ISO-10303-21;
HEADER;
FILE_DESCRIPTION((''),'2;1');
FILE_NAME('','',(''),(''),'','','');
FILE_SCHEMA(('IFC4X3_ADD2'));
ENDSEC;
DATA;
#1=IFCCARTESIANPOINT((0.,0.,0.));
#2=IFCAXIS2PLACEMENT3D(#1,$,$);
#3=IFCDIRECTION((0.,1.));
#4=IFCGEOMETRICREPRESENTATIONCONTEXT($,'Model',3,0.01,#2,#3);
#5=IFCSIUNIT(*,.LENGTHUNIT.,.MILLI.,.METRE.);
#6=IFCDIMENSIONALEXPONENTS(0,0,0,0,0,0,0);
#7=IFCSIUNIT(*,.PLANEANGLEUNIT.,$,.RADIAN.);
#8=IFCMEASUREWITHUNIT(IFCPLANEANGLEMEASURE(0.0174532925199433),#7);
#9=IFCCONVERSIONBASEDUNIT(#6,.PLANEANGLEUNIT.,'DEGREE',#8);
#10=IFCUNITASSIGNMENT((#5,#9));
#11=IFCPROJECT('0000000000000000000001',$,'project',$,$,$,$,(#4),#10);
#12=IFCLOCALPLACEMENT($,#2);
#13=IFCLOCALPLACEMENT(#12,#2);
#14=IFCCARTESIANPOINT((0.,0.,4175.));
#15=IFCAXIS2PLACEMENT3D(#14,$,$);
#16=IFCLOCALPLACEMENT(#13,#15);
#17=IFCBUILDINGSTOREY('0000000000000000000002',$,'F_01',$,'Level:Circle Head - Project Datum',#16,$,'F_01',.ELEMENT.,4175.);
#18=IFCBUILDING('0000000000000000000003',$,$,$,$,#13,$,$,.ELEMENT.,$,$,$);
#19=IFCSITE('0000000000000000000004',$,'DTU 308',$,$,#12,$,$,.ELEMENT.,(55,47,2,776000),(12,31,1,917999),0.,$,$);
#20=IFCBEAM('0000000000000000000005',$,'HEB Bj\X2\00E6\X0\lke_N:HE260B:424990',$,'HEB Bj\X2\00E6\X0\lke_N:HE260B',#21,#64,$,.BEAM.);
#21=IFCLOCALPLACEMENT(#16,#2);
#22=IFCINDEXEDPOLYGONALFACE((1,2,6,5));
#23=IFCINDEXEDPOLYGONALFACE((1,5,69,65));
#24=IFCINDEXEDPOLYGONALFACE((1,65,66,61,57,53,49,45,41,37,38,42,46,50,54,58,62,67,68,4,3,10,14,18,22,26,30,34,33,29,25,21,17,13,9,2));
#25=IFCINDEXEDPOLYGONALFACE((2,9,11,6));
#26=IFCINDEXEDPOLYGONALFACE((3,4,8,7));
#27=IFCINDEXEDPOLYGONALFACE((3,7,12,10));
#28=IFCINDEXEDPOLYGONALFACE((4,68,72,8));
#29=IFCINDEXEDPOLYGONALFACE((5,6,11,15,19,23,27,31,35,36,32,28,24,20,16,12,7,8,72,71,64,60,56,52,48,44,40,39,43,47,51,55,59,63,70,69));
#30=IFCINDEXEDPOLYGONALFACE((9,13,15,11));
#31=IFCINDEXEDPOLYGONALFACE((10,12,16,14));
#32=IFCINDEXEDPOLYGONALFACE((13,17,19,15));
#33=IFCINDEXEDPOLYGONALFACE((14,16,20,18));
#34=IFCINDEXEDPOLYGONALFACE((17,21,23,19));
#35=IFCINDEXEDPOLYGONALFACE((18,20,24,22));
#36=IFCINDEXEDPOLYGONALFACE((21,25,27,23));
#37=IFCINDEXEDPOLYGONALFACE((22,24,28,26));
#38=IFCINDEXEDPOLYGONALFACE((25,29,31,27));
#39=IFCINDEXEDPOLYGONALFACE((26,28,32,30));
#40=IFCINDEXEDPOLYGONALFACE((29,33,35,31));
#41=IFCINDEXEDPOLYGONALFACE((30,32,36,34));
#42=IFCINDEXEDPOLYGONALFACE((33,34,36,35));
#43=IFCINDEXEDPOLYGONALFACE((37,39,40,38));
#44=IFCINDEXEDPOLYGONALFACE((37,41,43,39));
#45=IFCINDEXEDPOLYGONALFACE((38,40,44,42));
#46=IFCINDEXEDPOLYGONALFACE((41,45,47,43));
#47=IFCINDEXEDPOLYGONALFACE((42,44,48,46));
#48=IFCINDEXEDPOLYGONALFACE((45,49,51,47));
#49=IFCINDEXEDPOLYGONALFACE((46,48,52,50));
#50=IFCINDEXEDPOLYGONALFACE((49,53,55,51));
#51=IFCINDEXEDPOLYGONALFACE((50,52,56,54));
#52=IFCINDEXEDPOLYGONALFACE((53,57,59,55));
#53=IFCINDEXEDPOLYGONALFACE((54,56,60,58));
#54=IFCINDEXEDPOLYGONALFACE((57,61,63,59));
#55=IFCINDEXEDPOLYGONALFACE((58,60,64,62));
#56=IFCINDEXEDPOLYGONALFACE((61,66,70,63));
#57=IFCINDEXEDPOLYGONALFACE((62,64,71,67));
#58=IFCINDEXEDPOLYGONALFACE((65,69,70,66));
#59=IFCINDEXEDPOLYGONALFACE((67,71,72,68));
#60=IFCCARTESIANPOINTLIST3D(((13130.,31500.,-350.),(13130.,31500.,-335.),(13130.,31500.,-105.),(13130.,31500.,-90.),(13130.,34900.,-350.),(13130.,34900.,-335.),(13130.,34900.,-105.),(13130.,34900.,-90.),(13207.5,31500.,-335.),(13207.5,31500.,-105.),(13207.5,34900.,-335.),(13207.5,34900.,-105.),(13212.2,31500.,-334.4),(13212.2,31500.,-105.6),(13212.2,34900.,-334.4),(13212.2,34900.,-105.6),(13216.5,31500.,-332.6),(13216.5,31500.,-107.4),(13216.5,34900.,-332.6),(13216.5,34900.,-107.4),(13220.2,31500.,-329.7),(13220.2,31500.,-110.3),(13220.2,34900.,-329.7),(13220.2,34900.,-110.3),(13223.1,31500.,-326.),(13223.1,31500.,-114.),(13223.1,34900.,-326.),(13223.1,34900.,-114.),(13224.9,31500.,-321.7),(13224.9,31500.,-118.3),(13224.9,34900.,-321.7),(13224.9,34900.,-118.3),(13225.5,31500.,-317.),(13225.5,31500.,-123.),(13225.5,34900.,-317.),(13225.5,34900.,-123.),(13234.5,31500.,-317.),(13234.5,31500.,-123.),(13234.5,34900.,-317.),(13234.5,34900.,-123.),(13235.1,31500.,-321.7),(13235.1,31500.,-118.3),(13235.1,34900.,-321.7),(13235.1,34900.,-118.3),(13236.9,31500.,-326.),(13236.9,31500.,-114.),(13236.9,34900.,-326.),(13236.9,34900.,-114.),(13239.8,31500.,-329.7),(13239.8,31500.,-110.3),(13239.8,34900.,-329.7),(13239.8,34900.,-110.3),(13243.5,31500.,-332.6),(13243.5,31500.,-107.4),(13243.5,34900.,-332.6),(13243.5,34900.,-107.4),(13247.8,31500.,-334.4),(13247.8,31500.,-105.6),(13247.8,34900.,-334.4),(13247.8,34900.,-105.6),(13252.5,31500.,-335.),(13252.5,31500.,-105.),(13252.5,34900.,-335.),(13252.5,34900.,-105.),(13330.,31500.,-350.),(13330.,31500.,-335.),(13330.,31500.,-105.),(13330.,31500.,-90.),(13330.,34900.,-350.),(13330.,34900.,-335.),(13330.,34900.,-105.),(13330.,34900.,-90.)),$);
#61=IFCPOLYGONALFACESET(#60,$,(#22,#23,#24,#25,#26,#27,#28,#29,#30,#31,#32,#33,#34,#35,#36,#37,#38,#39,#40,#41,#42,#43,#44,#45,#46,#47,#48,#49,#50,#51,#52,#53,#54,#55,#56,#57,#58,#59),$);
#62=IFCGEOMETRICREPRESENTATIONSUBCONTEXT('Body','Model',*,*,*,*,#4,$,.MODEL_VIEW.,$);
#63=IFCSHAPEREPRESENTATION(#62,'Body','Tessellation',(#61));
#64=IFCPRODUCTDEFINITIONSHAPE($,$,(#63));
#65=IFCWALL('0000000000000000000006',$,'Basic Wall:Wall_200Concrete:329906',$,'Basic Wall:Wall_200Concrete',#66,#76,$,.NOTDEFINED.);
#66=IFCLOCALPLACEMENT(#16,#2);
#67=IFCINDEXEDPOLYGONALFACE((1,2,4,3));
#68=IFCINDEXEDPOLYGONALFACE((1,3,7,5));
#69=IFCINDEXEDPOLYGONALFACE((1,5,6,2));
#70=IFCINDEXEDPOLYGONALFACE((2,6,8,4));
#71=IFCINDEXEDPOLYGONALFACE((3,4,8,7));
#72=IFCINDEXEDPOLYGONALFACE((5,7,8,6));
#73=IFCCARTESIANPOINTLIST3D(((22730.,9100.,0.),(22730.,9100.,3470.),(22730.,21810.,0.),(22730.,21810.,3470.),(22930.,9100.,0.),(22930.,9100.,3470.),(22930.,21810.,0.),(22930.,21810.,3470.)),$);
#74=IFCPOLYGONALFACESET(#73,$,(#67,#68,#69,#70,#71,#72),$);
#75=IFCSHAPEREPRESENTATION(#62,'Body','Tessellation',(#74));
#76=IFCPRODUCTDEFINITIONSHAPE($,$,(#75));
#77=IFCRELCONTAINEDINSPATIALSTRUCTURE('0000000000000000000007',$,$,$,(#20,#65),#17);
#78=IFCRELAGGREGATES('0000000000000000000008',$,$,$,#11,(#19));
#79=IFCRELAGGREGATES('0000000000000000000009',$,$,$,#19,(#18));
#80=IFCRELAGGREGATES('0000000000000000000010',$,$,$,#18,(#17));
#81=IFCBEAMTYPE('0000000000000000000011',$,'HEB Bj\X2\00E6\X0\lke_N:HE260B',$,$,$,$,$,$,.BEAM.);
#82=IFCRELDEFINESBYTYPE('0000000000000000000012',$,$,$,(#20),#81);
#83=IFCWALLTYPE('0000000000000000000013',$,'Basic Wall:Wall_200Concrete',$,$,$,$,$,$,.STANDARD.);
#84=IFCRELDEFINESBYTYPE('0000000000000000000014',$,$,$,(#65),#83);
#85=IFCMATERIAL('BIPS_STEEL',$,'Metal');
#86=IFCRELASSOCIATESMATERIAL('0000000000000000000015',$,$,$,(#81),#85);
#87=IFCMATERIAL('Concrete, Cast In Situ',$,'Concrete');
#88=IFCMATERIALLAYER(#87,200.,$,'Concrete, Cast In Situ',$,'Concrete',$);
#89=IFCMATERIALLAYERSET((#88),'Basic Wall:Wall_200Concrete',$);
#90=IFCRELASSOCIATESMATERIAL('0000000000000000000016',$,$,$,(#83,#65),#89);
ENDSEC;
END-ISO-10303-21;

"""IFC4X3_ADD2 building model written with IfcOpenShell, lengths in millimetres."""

from ifc_helpers import new_model, entity, si_unit, converted_unit, direction, frame, frame_2d, origin, place, context, subcontext, project, spatial, polyline, circle_curve, parameter, trimmed, segment, composite_curve, rectangle, i_section, outline, extrude, source, transform, mapped, material, layer, layer_set, material_profile, profile_set, type_object, element, save


model = new_model("IFC4X3_ADD2")

# Units and contexts
model_context = context("Model", 3, precision=0.01, world=origin(), true_north=direction((0.0, 1.0)))
body_context = subcontext(model_context, "Body", "Model", "MODEL_VIEW")
ifc_project = project(units=[si_unit("LENGTHUNIT", "METRE", prefix="MILLI"), converted_unit("PLANEANGLEUNIT", "DEGREE", entity("IfcPlaneAngleMeasure", 0.0174532925199433), si_unit("PLANEANGLEUNIT", "RADIAN"), dimensions=[0, 0, 0, 0, 0, 0, 0])], contexts=[model_context])

# Site, building, storey
site_placement = place(None, origin())
site = spatial("IfcSite", under=ifc_project, at=site_placement, Name="DTU 308", CompositionType="ELEMENT", RefLatitude=(55, 47, 2, 776000), RefLongitude=(12, 31, 1, 917999), RefElevation=0.0)
building_placement = place(site_placement, origin())
building = spatial("IfcBuilding", under=site, at=building_placement, CompositionType="ELEMENT")
storey_placement = place(building_placement, frame((0.0, 0.0, 4175.0)))
storey = spatial("IfcBuildingStorey", under=building, at=storey_placement, Name="F_01", ObjectType="Level:Circle Head - Project Datum", LongName="F_01", CompositionType="ELEMENT", Elevation=4175.0)

# Shared definitions
ifc_material_1 = material(Name="BIPS_STEEL", Category="Metal")

# Beam
ifc_material_profile_1 = material_profile(ifc_material_1, i_section(OverallWidth=200.0, OverallDepth=260.0, WebThickness=9.0, FlangeThickness=15.0, FilletRadius=18.0, at=frame_2d((0.0, 0.0), x_axis=(1.0, 0.0))), Name="HE260B")
ifc_profile_set_1 = profile_set([ifc_material_profile_1], Name="HE260B")
beam_type_1 = type_object("IfcBeamType", Name="HEB Bjælke_N:HE260B", PredefinedType="BEAM", material=ifc_profile_set_1)
shared_shape_1 = source(origin(), body_context, "Body", "SweptSolid", [
    extrude(outline(composite_curve([segment(polyline([(-100.0, -115.0), (-100.0, -130.0)]), True, "CONTINUOUS"), segment(polyline([(-100.0, -130.0), (100.0, -130.0)]), True, "CONTINUOUS"), segment(polyline([(100.0, -130.0), (100.0, -115.0)]), True, "CONTINUOUS"), segment(polyline([(100.0, -115.0), (22.5, -115.0)]), True, "CONTINUOUS"), segment(trimmed(circle_curve(frame_2d((22.5, -97.0), x_axis=(1.0, 0.0)), 18.0), [parameter(180.0)], [parameter(270.0)], True, "PARAMETER"), False, "CONTINUOUS"), segment(polyline([(4.5, -97.0), (4.5, 97.0)]), True, "CONTINUOUS"), segment(trimmed(circle_curve(frame_2d((22.5, 97.0), x_axis=(1.0, 0.0)), 18.0), [parameter(90.0)], [parameter(180.0)], True, "PARAMETER"), False, "CONTINUOUS"), segment(polyline([(22.5, 115.0), (100.0, 115.0)]), True, "CONTINUOUS"), segment(polyline([(100.0, 115.0), (100.0, 130.0)]), True, "CONTINUOUS"), segment(polyline([(100.0, 130.0), (-100.0, 130.0)]), True, "CONTINUOUS"), segment(polyline([(-100.0, 130.0), (-100.0, 115.0)]), True, "CONTINUOUS"), segment(polyline([(-100.0, 115.0), (-22.5, 115.0)]), True, "CONTINUOUS"), segment(trimmed(circle_curve(frame_2d((-22.5, 97.0), x_axis=(1.0, 0.0)), 18.0), [parameter(360.0)], [parameter(90.0)], True, "PARAMETER"), False, "CONTINUOUS"), segment(polyline([(-4.5, 97.0), (-4.5, -97.0)]), True, "CONTINUOUS"), segment(trimmed(circle_curve(frame_2d((-22.5, -97.0), x_axis=(1.0, 0.0)), 18.0), [parameter(270.0)], [parameter(360.0)], True, "PARAMETER"), False, "CONTINUOUS"), segment(polyline([(-22.5, -115.0), (-100.0, -115.0)]), True, "CONTINUOUS")], self_intersect=False)), frame((-450.0, 0.0, 0.0), z_axis=(-1.0, 0.0, 0.0), x_axis=(0.0, -1.0, 0.0)), (0.0, 0.0, -1.0), 3400.0),
])
beam_1_placement = place(storey_placement, frame((13230.0, 34450.0, -220.0), z_axis=(0.0, 0.0, 1.0), x_axis=(0.0, -1.0, 0.0)))
element("IfcBeam", 1, at=beam_1_placement, inside=storey, type_object=beam_type_1, Name="HEB Bjælke_N:HE260B:424990", ObjectType="HEB Bjælke_N:HE260B", PredefinedType="BEAM", context=body_context, shape_type="MappedRepresentation", body=[
    mapped(shared_shape_1, transform((0.0, 0.0, 0.0), scale=1.0)),
])

# Wall
ifc_material_2 = material(Name="Concrete, Cast In Situ", Category="Concrete")
ifc_layer = layer(ifc_material_2, 200.0, Name="Concrete, Cast In Situ", Category="Concrete")
ifc_layer_set = layer_set([ifc_layer], Name="Basic Wall:Wall_200Concrete")
wall_type = type_object("IfcWallType", Name="Basic Wall:Wall_200Concrete", PredefinedType="STANDARD", material=ifc_layer_set)
wall_placement = place(storey_placement, frame((22830.0, 21810.0, 0.0), z_axis=(0.0, 0.0, 1.0), x_axis=(0.0, -1.0, 0.0)))
element("IfcWall", 2, at=wall_placement, inside=storey, type_object=wall_type, material=ifc_layer_set, Name="Basic Wall:Wall_200Concrete:329906", ObjectType="Basic Wall:Wall_200Concrete", PredefinedType="NOTDEFINED", context=body_context, shape_type="SweptSolid", body=[
    extrude(rectangle(XDim=12710.0, YDim=200.0, at=frame_2d((6355.0, 0.0), x_axis=(-1.0, 0.0))), origin(), (0.0, 0.0, 1.0), 3470.0),
])

save(model, "model.ifc")
